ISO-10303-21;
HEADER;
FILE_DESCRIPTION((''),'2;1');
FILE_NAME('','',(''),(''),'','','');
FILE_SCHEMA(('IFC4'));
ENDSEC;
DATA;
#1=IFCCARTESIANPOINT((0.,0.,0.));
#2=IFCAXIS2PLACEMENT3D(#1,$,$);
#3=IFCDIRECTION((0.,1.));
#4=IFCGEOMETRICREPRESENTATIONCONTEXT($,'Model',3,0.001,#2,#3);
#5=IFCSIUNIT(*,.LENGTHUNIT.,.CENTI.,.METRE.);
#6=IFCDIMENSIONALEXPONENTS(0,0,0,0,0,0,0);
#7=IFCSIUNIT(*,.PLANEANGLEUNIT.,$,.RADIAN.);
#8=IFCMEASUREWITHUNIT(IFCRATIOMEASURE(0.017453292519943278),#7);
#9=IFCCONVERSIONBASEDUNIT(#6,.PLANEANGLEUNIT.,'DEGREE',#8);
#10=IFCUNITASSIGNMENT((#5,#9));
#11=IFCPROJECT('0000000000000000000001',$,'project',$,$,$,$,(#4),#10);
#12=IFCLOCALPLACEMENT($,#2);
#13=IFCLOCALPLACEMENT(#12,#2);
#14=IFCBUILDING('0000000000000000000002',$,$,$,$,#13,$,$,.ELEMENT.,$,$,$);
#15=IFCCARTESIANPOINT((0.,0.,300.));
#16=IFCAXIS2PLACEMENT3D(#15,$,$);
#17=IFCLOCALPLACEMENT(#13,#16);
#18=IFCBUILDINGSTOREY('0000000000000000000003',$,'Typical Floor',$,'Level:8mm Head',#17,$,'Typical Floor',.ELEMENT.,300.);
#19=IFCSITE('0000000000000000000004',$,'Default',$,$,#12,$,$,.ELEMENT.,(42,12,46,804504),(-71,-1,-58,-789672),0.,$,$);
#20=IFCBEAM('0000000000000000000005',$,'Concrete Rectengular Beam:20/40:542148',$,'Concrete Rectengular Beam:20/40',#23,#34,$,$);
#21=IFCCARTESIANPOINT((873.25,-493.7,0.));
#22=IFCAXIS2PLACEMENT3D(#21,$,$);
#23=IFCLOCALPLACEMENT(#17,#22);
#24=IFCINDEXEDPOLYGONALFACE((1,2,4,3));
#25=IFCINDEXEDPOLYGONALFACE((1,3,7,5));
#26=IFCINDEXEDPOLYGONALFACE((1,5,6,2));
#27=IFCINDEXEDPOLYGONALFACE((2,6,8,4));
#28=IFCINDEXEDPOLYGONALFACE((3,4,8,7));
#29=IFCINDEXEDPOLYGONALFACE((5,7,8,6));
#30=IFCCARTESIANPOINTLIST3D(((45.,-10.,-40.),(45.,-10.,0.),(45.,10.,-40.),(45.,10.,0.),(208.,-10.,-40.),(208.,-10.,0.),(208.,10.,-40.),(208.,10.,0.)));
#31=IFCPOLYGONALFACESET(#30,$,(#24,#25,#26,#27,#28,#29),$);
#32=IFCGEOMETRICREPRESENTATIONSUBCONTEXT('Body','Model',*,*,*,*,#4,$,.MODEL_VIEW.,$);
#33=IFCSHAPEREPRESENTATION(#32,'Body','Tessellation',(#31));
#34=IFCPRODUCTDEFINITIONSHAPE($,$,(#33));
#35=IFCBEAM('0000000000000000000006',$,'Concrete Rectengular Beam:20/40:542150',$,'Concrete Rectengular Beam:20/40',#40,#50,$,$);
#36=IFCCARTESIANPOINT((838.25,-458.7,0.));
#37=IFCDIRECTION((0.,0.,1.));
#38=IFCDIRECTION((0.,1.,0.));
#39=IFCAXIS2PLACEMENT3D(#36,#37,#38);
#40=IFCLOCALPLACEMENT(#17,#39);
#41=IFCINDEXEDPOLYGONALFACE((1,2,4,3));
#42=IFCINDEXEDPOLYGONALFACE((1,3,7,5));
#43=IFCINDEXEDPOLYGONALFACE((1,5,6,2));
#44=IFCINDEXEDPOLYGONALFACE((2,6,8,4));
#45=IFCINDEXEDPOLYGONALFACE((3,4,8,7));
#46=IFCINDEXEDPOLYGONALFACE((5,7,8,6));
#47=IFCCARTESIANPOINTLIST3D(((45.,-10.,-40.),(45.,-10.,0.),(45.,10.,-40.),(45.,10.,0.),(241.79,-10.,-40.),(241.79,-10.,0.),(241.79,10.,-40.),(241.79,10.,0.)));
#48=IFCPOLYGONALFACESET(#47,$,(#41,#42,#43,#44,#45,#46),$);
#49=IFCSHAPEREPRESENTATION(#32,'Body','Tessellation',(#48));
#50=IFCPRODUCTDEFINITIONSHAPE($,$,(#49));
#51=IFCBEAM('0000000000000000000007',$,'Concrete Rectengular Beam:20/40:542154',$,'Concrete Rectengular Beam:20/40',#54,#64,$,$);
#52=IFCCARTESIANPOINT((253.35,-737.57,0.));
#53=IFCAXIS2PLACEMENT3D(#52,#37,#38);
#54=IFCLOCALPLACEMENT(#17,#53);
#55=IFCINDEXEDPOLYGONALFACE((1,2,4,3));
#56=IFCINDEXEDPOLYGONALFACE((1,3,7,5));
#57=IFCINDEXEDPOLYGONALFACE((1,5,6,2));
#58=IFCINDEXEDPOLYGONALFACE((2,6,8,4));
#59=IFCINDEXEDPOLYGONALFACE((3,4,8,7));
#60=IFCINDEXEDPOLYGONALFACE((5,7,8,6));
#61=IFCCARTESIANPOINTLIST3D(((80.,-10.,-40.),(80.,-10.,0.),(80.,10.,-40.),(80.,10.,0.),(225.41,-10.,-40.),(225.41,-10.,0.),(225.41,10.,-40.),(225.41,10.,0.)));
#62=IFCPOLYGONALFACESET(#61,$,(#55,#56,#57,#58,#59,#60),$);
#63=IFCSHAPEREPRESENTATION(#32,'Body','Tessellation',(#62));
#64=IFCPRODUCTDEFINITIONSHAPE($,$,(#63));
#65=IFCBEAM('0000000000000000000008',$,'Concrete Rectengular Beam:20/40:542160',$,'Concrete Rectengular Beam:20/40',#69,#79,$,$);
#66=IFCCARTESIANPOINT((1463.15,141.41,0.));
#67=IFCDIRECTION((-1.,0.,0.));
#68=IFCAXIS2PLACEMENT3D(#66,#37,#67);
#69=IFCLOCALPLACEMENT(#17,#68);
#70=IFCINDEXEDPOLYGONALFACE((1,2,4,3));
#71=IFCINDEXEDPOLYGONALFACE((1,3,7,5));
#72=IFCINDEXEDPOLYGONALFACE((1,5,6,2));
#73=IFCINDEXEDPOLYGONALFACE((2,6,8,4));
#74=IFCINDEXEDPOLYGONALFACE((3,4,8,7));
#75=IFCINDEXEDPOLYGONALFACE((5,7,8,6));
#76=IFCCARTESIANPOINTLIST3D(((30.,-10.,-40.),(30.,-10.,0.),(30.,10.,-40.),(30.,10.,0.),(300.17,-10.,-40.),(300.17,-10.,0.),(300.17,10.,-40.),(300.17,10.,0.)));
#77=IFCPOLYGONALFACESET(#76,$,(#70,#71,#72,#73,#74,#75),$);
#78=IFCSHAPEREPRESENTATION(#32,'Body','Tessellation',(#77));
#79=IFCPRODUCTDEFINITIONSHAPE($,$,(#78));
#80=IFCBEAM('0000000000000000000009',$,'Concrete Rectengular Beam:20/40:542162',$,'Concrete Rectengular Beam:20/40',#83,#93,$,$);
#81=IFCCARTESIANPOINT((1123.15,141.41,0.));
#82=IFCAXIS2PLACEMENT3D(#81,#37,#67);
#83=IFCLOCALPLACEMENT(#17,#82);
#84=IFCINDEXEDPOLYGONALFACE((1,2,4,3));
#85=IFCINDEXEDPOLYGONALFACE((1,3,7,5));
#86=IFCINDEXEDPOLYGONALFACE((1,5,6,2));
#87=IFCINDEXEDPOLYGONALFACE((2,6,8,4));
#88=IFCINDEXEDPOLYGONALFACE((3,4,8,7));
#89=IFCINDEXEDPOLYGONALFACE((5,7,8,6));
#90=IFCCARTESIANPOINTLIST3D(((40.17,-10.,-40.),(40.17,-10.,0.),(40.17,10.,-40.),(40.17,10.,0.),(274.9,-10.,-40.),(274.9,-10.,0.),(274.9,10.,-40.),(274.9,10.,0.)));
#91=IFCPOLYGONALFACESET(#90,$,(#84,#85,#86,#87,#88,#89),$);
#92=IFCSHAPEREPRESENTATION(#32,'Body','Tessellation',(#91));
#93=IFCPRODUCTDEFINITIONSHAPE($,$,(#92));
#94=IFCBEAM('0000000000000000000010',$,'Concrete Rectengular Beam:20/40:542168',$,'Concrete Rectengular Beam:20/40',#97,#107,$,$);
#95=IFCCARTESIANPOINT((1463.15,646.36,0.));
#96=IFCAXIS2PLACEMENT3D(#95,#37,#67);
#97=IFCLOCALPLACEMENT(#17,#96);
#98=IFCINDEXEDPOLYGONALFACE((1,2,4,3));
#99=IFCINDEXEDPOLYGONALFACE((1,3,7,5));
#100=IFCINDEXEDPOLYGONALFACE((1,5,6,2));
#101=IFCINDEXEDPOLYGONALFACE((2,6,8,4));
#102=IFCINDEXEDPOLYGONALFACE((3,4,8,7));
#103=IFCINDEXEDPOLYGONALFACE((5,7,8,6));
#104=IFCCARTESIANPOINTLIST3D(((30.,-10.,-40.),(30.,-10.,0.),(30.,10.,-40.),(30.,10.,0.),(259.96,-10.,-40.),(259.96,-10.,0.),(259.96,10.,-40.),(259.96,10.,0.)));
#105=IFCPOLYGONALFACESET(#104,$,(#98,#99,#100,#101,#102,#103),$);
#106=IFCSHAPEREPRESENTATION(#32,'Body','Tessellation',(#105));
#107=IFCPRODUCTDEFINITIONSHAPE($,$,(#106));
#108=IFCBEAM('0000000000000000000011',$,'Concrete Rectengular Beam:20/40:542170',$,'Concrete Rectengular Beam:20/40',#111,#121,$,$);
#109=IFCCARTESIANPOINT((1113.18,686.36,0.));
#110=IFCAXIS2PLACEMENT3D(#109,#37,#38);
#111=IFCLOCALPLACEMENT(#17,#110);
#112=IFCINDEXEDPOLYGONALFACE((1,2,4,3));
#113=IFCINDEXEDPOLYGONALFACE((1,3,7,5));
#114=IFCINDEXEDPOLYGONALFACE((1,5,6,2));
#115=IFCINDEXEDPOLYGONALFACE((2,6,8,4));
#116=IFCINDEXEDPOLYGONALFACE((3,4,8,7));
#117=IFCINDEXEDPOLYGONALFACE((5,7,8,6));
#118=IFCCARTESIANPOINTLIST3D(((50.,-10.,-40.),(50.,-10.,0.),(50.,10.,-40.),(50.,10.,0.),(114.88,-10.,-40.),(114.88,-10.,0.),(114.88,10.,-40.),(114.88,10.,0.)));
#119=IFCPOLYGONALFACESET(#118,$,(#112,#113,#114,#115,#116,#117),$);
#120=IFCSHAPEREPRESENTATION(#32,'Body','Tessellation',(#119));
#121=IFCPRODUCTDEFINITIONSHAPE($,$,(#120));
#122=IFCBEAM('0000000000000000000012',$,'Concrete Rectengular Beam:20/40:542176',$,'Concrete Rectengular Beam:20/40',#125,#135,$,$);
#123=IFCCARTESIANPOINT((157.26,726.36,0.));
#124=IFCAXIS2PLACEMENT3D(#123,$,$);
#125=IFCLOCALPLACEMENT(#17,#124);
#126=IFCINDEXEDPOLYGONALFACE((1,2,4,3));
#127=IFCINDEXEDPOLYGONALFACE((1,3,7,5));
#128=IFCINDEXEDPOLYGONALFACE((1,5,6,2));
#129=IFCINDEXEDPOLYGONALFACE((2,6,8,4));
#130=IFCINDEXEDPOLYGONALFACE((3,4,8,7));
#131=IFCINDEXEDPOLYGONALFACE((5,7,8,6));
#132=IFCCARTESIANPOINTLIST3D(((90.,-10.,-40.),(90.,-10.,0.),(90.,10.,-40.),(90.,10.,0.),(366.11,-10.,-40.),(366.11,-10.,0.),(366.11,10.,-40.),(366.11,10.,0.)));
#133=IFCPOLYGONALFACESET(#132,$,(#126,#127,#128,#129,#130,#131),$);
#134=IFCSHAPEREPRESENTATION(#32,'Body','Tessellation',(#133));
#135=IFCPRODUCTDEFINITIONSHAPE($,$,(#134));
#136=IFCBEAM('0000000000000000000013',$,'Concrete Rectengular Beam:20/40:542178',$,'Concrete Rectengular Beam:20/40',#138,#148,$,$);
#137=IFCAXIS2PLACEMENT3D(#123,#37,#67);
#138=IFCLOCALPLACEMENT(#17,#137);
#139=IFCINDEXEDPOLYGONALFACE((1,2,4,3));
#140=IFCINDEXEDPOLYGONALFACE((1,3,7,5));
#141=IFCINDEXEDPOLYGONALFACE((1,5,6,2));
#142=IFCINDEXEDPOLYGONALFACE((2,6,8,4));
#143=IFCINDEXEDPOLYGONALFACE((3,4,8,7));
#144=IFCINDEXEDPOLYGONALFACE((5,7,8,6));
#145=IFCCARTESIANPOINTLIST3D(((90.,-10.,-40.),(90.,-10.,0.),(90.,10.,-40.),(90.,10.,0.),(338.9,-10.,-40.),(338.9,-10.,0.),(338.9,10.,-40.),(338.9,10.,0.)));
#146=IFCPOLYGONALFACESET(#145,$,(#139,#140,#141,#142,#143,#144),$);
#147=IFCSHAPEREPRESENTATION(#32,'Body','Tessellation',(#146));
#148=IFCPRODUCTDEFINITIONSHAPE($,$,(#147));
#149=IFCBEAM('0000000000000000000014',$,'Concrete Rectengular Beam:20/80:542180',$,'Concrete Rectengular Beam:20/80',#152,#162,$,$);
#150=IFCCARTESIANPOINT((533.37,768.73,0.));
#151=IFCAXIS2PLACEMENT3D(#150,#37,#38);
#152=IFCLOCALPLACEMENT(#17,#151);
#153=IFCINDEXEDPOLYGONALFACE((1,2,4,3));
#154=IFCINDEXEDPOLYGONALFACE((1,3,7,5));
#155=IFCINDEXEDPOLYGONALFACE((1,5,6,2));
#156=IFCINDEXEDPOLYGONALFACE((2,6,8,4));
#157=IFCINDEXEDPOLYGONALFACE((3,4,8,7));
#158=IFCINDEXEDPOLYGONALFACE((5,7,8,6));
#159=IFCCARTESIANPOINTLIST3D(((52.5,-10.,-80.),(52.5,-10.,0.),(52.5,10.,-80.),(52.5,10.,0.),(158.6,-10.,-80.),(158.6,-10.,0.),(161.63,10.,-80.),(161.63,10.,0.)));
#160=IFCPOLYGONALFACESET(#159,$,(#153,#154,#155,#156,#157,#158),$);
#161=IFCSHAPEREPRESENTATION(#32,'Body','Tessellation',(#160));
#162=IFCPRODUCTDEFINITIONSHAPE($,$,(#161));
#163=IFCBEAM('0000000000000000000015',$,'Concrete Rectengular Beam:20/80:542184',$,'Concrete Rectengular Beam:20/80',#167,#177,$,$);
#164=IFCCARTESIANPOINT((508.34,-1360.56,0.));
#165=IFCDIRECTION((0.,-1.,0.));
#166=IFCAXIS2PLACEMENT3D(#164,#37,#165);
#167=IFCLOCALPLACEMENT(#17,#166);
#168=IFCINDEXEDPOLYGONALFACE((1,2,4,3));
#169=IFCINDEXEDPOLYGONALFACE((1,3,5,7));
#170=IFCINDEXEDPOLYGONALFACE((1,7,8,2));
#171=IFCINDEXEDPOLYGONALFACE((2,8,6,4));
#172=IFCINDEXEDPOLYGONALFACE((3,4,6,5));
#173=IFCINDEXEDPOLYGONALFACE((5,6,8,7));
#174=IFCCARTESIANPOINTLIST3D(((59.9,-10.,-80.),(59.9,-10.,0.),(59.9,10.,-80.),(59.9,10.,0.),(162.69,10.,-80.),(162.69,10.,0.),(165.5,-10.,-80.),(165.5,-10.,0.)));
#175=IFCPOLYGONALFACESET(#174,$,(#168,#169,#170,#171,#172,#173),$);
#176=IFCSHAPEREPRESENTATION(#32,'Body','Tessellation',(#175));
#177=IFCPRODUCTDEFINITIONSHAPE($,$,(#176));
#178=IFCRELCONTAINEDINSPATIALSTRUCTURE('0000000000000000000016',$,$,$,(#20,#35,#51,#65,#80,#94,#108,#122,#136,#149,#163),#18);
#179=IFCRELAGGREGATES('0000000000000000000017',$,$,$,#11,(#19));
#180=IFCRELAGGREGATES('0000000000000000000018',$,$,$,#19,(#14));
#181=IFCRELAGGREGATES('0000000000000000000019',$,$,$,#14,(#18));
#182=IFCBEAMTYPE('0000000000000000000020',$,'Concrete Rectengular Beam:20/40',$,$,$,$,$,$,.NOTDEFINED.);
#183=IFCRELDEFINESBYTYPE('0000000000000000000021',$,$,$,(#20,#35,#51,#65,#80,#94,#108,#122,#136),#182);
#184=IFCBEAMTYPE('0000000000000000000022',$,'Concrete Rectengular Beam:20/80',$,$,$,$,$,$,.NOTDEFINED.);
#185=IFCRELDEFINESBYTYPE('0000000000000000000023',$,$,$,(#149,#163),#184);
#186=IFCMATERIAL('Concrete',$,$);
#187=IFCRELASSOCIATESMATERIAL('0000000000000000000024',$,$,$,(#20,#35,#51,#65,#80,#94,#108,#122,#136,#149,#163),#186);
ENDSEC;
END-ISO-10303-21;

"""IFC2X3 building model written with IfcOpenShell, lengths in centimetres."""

from ifc_helpers import new_model, entity, si_unit, converted_unit, direction, frame, frame_2d, origin, origin_2d_with_axis, place, context, subcontext, project, spatial, rectangle, extrude, clip, halfspace, material, type_object, element, save


model = new_model("IFC2X3")

# Units and contexts
model_context = context("Model", 3, precision=0.001, world=origin(), true_north=direction((0.0, 1.0)))
body_context = subcontext(model_context, "Body", "Model", "MODEL_VIEW")
ifc_project = project(units=[si_unit("LENGTHUNIT", "METRE", prefix="CENTI"), converted_unit("PLANEANGLEUNIT", "DEGREE", entity("IfcRatioMeasure", 0.017453292519943278), si_unit("PLANEANGLEUNIT", "RADIAN"), dimensions=[0, 0, 0, 0, 0, 0, 0])], contexts=[model_context])

# Site, building, storey
site_placement = place(None, origin())
site = spatial("IfcSite", under=ifc_project, at=site_placement, Name="Default", CompositionType="ELEMENT", RefLatitude=(42, 12, 46, 804504), RefLongitude=(-71, -1, -58, -789672), RefElevation=0.0)
building_placement = place(site_placement, origin())
building = spatial("IfcBuilding", under=site, at=building_placement, CompositionType="ELEMENT")
storey_placement = place(building_placement, frame((0.0, 0.0, 300.0)))
storey = spatial("IfcBuildingStorey", under=building, at=storey_placement, Name="Typical Floor", ObjectType="Level:8mm Head", LongName="Typical Floor", CompositionType="ELEMENT", Elevation=300.0)

# Beams
ifc_material = material(Name="Concrete")
beam_type_1 = type_object("IfcBeamType", Name="Concrete Rectengular Beam:20/40", PredefinedType="NOTDEFINED")
beam_1_placement = place(storey_placement, frame((873.25, -493.7, 0.0)))
element("IfcBeam", 1, at=beam_1_placement, inside=storey, type_object=beam_type_1, material=ifc_material, Name="Concrete Rectengular Beam:20/40:542148", ObjectType="Concrete Rectengular Beam:20/40", context=body_context, shape_type="SweptSolid", body=[
    extrude(rectangle(XDim=40.0, YDim=20.0, at=frame_2d((0.0, 0.0), x_axis=(1.0, 0.0))), frame((45.0, 0.0, -20.0), z_axis=(1.0, 0.0, 0.0), x_axis=(0.0, 0.0, -1.0)), (0.0, 0.0, 1.0), 163.0),
])
beam_2_placement = place(storey_placement, frame((838.25, -458.7, 0.0), z_axis=(0.0, 0.0, 1.0), x_axis=(0.0, 1.0, 0.0)))
element("IfcBeam", 2, at=beam_2_placement, inside=storey, type_object=beam_type_1, material=ifc_material, Name="Concrete Rectengular Beam:20/40:542150", ObjectType="Concrete Rectengular Beam:20/40", context=body_context, shape_type="SweptSolid", body=[
    extrude(rectangle(XDim=40.0, YDim=20.0, at=origin_2d_with_axis()), frame((45.0, 0.0, -20.0), z_axis=(1.0, 0.0, 0.0), x_axis=(0.0, 0.0, -1.0)), (0.0, 0.0, 1.0), 196.79),
])
beam_3_placement = place(storey_placement, frame((253.35, -737.57, 0.0), z_axis=(0.0, 0.0, 1.0), x_axis=(0.0, 1.0, 0.0)))
element("IfcBeam", 3, at=beam_3_placement, inside=storey, type_object=beam_type_1, material=ifc_material, Name="Concrete Rectengular Beam:20/40:542154", ObjectType="Concrete Rectengular Beam:20/40", context=body_context, shape_type="SweptSolid", body=[
    extrude(rectangle(XDim=40.0, YDim=20.0, at=origin_2d_with_axis()), frame((80.0, 0.0, -20.0), z_axis=(1.0, 0.0, 0.0), x_axis=(0.0, 0.0, -1.0)), (0.0, 0.0, 1.0), 145.41),
])
beam_4_placement = place(storey_placement, frame((1463.15, 141.41, 0.0), z_axis=(0.0, 0.0, 1.0), x_axis=(-1.0, 0.0, 0.0)))
element("IfcBeam", 4, at=beam_4_placement, inside=storey, type_object=beam_type_1, material=ifc_material, Name="Concrete Rectengular Beam:20/40:542160", ObjectType="Concrete Rectengular Beam:20/40", context=body_context, shape_type="SweptSolid", body=[
    extrude(rectangle(XDim=40.0, YDim=20.0, at=frame_2d((0.0, 0.0), x_axis=(1.0, 0.0))), frame((30.0, 0.0, -20.0), z_axis=(1.0, 0.0, 0.0), x_axis=(0.0, 0.0, -1.0)), (0.0, 0.0, 1.0), 270.17),
])
beam_5_placement = place(storey_placement, frame((1123.15, 141.41, 0.0), z_axis=(0.0, 0.0, 1.0), x_axis=(-1.0, 0.0, 0.0)))
element("IfcBeam", 5, at=beam_5_placement, inside=storey, type_object=beam_type_1, material=ifc_material, Name="Concrete Rectengular Beam:20/40:542162", ObjectType="Concrete Rectengular Beam:20/40", context=body_context, shape_type="SweptSolid", body=[
    extrude(rectangle(XDim=40.0, YDim=20.0, at=frame_2d((0.0, 0.0), x_axis=(1.0, 0.0))), frame((40.17, 0.0, -20.0), z_axis=(1.0, 0.0, 0.0), x_axis=(0.0, 0.0, -1.0)), (0.0, 0.0, 1.0), 234.72),
])
beam_6_placement = place(storey_placement, frame((1463.15, 646.36, 0.0), z_axis=(0.0, 0.0, 1.0), x_axis=(-1.0, 0.0, 0.0)))
element("IfcBeam", 6, at=beam_6_placement, inside=storey, type_object=beam_type_1, material=ifc_material, Name="Concrete Rectengular Beam:20/40:542168", ObjectType="Concrete Rectengular Beam:20/40", context=body_context, shape_type="SweptSolid", body=[
    extrude(rectangle(XDim=40.0, YDim=20.0, at=frame_2d((0.0, 0.0), x_axis=(1.0, 0.0))), frame((30.0, 0.0, -20.0), z_axis=(1.0, 0.0, 0.0), x_axis=(0.0, 0.0, -1.0)), (0.0, 0.0, 1.0), 229.96),
])
beam_7_placement = place(storey_placement, frame((1113.18, 686.36, 0.0), z_axis=(0.0, 0.0, 1.0), x_axis=(0.0, 1.0, 0.0)))
element("IfcBeam", 7, at=beam_7_placement, inside=storey, type_object=beam_type_1, material=ifc_material, Name="Concrete Rectengular Beam:20/40:542170", ObjectType="Concrete Rectengular Beam:20/40", context=body_context, shape_type="SweptSolid", body=[
    extrude(rectangle(XDim=40.0, YDim=20.0, at=origin_2d_with_axis()), frame((50.0, 0.0, -20.0), z_axis=(1.0, 0.0, 0.0), x_axis=(0.0, 0.0, -1.0)), (0.0, 0.0, 1.0), 64.88),
])
beam_8_placement = place(storey_placement, frame((157.26, 726.36, 0.0)))
element("IfcBeam", 8, at=beam_8_placement, inside=storey, type_object=beam_type_1, material=ifc_material, Name="Concrete Rectengular Beam:20/40:542176", ObjectType="Concrete Rectengular Beam:20/40", context=body_context, shape_type="SweptSolid", body=[
    extrude(rectangle(XDim=40.0, YDim=20.0, at=frame_2d((0.0, 0.0), x_axis=(1.0, 0.0))), frame((90.0, 0.0, -20.0), z_axis=(1.0, 0.0, 0.0), x_axis=(0.0, 0.0, -1.0)), (0.0, 0.0, 1.0), 276.11),
])
beam_9_placement = place(storey_placement, frame((157.26, 726.36, 0.0), z_axis=(0.0, 0.0, 1.0), x_axis=(-1.0, 0.0, 0.0)))
element("IfcBeam", 9, at=beam_9_placement, inside=storey, type_object=beam_type_1, material=ifc_material, Name="Concrete Rectengular Beam:20/40:542178", ObjectType="Concrete Rectengular Beam:20/40", context=body_context, shape_type="SweptSolid", body=[
    extrude(rectangle(XDim=40.0, YDim=20.0, at=frame_2d((0.0, 0.0), x_axis=(1.0, 0.0))), frame((90.0, 0.0, -20.0), z_axis=(1.0, 0.0, 0.0), x_axis=(0.0, 0.0, -1.0)), (0.0, 0.0, 1.0), 248.9),
])
beam_type_2 = type_object("IfcBeamType", Name="Concrete Rectengular Beam:20/80", PredefinedType="NOTDEFINED")
beam_10_placement = place(storey_placement, frame((533.37, 768.73, 0.0), z_axis=(0.0, 0.0, 1.0), x_axis=(0.0, 1.0, 0.0)))
element("IfcBeam", 10, at=beam_10_placement, inside=storey, type_object=beam_type_2, material=ifc_material, Name="Concrete Rectengular Beam:20/80:542180", ObjectType="Concrete Rectengular Beam:20/80", context=body_context, shape_type="SweptSolid", body=[
    clip(extrude(rectangle(XDim=80.0, YDim=20.0, at=frame_2d((0.0, 0.0), x_axis=(1.0, 0.0))), frame((52.5, 0.0, -40.0), z_axis=(1.0, 0.0, 0.0), x_axis=(0.0, 0.0, -1.0)), (0.0, 0.0, 1.0), 109.13), halfspace(frame((157.97, -14.17, -80.0), z_axis=(0.988733, -0.14969, 0.0), x_axis=(0.14969, 0.988733, 0.0)), False)),
])
beam_11_placement = place(storey_placement, frame((508.34, -1360.56, 0.0), z_axis=(0.0, 0.0, 1.0), x_axis=(0.0, -1.0, 0.0)))
element("IfcBeam", 11, at=beam_11_placement, inside=storey, type_object=beam_type_2, material=ifc_material, Name="Concrete Rectengular Beam:20/80:542184", ObjectType="Concrete Rectengular Beam:20/80", context=body_context, shape_type="SweptSolid", body=[
    clip(extrude(rectangle(XDim=80.0, YDim=20.0, at=frame_2d((0.0, 0.0), x_axis=(1.0, 0.0))), frame((59.9, 0.0, -40.0), z_axis=(1.0, 0.0, 0.0), x_axis=(0.0, 0.0, -1.0)), (0.0, 0.0, 1.0), 105.61), halfspace(frame((162.13, 14.02, 0.0), z_axis=(0.990268, 0.139173, 0.0), x_axis=(0.139173, -0.990268, 0.0)), False)),
])

save(model, "model.ifc")
